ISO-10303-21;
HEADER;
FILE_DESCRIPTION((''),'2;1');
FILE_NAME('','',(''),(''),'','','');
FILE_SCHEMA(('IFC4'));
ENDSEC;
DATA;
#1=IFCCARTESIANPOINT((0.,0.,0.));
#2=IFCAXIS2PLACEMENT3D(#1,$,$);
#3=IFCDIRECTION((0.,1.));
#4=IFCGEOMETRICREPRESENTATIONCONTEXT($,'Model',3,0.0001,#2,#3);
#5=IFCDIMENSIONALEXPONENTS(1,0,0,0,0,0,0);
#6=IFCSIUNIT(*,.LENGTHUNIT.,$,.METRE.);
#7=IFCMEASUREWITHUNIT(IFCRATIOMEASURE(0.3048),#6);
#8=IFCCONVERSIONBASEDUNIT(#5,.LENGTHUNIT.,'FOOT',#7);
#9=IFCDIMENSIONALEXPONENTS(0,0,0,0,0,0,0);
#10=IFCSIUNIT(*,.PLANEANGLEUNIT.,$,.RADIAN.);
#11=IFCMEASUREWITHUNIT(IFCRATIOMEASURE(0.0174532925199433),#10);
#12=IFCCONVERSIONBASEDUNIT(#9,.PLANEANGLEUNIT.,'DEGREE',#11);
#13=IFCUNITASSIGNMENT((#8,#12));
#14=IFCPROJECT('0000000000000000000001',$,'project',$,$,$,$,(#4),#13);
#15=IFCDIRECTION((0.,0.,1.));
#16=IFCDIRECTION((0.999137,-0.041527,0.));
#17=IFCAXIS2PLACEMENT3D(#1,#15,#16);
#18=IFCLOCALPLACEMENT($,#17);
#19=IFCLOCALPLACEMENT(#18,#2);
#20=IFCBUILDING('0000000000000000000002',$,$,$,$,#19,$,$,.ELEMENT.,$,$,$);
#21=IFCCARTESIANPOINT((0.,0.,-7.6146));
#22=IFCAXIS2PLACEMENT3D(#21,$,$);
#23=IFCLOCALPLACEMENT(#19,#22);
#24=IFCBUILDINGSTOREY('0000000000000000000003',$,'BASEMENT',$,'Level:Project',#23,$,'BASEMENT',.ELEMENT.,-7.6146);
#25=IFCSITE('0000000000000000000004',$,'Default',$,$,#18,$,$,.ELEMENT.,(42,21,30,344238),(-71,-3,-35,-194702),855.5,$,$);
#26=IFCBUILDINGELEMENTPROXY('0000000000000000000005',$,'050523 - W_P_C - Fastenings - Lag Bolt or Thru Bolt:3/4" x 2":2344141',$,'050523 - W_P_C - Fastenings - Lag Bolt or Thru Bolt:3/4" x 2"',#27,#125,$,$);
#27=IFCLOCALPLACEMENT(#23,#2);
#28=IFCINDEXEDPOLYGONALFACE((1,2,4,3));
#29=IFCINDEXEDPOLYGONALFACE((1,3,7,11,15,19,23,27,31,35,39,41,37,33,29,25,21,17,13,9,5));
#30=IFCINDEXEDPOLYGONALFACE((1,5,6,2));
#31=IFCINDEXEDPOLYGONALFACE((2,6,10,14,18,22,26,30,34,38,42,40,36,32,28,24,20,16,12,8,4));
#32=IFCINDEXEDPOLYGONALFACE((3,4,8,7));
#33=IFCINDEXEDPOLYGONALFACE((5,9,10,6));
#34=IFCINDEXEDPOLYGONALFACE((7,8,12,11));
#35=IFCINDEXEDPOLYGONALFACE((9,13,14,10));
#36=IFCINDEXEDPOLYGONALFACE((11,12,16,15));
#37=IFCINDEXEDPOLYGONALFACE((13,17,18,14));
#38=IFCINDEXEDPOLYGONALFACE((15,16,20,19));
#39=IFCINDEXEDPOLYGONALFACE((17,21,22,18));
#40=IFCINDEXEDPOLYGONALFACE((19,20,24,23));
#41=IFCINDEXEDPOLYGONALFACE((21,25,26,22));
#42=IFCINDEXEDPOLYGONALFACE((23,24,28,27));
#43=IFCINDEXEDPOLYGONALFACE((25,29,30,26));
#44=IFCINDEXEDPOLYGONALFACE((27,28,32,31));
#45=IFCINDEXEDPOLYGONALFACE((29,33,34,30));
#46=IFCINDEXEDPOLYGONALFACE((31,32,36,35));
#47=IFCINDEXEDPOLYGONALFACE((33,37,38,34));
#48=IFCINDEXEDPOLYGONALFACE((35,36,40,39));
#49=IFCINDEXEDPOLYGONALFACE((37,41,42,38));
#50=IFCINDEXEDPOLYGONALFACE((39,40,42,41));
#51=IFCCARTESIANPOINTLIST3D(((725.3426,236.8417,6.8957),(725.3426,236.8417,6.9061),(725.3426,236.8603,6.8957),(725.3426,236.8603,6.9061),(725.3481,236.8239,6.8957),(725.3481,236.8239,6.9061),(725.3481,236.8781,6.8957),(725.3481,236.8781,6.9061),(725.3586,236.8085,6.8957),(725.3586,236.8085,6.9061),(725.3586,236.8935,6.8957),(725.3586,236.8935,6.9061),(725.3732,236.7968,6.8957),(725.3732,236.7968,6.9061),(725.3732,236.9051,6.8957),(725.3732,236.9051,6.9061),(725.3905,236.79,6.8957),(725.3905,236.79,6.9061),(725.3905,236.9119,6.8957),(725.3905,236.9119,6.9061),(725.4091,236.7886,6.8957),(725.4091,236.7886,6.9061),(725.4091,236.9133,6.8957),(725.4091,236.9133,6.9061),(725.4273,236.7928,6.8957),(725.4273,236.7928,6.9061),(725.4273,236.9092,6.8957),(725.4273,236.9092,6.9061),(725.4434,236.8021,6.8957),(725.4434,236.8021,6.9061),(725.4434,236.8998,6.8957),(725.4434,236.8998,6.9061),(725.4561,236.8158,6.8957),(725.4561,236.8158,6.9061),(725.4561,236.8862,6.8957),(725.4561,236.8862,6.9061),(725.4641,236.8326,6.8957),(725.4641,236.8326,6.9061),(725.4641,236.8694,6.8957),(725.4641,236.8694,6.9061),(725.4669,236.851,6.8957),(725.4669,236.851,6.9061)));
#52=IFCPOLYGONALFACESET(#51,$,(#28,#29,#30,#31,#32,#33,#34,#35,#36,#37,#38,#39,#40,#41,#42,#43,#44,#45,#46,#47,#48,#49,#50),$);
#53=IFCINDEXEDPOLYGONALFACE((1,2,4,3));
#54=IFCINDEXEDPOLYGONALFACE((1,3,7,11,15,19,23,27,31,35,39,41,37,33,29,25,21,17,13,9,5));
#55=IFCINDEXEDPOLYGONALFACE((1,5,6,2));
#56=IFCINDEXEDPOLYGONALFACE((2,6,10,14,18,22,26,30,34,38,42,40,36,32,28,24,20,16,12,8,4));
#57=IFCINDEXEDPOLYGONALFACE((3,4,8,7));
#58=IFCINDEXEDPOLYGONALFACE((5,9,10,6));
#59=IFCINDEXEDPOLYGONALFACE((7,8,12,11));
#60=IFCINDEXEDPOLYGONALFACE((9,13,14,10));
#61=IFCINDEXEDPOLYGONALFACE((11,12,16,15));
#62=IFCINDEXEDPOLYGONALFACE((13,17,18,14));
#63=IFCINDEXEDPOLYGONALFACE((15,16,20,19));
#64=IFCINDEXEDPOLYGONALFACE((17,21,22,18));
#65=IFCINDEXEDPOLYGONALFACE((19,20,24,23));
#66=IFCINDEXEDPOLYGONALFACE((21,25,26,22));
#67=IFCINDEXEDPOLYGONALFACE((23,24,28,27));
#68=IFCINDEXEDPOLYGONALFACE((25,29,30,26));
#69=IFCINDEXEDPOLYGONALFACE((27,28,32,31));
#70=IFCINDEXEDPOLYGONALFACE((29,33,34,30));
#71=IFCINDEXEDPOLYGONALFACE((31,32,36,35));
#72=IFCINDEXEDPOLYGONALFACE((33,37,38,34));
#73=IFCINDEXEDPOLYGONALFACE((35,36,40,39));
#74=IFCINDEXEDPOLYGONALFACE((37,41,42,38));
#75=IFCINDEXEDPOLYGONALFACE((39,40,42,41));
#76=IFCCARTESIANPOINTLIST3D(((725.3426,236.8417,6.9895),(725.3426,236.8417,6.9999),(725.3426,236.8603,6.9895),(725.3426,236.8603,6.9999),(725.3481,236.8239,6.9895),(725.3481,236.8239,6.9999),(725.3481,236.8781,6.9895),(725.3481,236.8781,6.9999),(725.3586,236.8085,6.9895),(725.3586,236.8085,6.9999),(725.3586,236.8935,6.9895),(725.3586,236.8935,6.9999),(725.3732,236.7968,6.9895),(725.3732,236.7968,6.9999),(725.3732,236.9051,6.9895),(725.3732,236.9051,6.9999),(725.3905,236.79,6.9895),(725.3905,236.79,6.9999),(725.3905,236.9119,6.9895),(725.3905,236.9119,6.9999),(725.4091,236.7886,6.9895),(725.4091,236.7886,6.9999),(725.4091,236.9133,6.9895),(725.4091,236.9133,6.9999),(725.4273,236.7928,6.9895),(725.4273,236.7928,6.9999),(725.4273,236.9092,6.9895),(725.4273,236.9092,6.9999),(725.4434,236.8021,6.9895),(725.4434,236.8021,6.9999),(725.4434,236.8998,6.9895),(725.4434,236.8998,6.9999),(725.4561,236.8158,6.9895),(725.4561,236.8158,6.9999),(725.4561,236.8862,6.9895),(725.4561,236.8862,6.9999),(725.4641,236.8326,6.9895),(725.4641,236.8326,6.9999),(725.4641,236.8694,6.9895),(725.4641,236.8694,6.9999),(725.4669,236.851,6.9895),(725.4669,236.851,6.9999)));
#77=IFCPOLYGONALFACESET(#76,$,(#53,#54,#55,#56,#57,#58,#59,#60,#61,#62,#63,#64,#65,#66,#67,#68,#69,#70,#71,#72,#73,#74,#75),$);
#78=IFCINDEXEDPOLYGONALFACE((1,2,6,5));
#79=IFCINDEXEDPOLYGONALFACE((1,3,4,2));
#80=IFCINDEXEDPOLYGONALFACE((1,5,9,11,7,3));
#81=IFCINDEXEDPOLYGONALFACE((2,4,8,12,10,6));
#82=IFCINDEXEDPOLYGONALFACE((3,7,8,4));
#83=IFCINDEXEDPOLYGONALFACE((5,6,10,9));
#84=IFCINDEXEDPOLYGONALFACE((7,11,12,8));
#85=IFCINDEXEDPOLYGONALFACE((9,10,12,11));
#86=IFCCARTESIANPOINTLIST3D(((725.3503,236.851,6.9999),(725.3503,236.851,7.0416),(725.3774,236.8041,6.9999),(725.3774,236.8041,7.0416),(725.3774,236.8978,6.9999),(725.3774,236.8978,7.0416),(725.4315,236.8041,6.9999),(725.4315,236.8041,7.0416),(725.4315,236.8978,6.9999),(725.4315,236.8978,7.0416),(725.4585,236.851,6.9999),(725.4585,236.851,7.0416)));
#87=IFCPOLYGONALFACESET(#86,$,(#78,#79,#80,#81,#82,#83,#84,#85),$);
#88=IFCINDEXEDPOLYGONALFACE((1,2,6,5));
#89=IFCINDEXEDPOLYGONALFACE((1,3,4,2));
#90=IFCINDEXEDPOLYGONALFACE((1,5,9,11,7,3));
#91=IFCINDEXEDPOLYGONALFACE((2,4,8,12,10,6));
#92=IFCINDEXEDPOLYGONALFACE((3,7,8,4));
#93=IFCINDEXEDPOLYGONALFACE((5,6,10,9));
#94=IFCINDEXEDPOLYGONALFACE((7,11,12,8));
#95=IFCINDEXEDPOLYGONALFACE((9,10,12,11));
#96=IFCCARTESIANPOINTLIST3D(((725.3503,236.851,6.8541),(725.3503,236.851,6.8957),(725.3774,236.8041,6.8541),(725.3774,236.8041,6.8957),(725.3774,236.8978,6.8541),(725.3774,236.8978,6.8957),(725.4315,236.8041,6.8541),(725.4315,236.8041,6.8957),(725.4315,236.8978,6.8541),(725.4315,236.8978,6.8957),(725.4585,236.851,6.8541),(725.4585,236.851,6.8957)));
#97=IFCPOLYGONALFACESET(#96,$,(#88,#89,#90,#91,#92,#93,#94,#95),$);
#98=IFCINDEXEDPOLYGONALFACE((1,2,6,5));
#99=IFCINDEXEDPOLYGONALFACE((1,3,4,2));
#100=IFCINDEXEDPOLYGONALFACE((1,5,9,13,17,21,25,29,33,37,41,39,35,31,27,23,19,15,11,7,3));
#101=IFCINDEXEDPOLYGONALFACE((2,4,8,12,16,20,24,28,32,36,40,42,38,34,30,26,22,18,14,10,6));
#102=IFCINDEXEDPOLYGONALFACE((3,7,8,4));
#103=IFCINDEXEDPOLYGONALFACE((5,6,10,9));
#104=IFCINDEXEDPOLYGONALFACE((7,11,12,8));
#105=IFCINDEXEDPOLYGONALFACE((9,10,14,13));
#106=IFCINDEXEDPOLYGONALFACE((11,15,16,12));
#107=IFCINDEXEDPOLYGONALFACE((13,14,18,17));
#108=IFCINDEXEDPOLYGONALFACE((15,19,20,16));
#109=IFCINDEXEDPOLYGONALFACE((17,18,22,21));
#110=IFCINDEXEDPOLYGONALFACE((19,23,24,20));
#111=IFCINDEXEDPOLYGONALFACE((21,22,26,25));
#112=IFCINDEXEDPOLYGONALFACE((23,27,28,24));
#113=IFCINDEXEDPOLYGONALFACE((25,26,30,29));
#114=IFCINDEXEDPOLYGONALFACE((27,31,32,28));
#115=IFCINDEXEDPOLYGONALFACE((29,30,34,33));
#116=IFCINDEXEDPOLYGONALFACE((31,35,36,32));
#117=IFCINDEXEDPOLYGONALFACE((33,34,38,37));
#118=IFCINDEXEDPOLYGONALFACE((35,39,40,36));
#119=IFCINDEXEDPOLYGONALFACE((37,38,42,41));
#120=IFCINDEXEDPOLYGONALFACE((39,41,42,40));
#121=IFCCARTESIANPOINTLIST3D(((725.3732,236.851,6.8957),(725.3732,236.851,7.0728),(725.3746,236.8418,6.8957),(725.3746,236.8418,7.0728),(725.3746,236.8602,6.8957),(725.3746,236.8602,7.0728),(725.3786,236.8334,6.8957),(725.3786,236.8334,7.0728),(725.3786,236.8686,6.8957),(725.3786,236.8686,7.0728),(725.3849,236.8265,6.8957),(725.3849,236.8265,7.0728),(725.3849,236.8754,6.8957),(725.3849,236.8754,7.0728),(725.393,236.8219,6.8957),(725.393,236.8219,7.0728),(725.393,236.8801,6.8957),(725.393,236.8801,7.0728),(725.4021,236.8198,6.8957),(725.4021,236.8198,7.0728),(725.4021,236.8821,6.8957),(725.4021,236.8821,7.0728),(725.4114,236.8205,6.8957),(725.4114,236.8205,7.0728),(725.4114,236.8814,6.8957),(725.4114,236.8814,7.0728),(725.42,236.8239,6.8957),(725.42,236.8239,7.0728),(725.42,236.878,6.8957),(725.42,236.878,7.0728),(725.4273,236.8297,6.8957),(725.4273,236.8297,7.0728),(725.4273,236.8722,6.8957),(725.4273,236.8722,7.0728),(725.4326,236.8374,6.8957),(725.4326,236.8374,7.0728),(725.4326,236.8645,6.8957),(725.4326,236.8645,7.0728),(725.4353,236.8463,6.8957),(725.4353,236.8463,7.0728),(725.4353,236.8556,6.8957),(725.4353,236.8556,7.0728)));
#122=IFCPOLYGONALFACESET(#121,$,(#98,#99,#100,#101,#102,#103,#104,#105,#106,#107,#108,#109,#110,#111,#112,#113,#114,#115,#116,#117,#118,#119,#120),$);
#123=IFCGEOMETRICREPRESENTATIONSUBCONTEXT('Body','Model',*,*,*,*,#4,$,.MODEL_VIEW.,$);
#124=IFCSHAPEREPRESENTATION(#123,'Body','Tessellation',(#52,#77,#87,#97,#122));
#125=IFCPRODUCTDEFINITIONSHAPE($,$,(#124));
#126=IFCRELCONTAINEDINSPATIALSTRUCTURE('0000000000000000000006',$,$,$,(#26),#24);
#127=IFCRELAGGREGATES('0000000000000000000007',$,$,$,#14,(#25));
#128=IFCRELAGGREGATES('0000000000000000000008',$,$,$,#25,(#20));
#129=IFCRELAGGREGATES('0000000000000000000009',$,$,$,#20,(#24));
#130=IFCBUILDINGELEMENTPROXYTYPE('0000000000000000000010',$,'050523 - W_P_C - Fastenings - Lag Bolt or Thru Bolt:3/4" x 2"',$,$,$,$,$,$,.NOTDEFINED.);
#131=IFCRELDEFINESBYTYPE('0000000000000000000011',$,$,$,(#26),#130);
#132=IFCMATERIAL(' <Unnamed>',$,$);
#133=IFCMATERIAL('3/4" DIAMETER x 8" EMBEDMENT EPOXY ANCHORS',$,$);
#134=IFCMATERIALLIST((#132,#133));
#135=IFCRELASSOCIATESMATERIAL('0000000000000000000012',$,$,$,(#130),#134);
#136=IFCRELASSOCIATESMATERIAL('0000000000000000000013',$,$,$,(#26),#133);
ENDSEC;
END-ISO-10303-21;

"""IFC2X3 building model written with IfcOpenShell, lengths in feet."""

from ifc_helpers import new_model, entity, si_unit, converted_unit, direction, frame, frame_2d, origin, place, context, subcontext, project, spatial, polyline, circle, outline, extrude, source, transform, mapped, material, material_list, type_object, type_shapes, element, save


model = new_model("IFC2X3")

# Units and contexts
model_context = context("Model", 3, precision=0.0001, world=origin(), true_north=direction((0.0, 1.0)))
body_context = subcontext(model_context, "Body", "Model", "MODEL_VIEW")
ifc_project = project(units=[converted_unit("LENGTHUNIT", "FOOT", entity("IfcRatioMeasure", 0.3048), si_unit("LENGTHUNIT", "METRE"), dimensions=[1, 0, 0, 0, 0, 0, 0]), converted_unit("PLANEANGLEUNIT", "DEGREE", entity("IfcRatioMeasure", 0.0174532925199433), si_unit("PLANEANGLEUNIT", "RADIAN"), dimensions=[0, 0, 0, 0, 0, 0, 0])], contexts=[model_context])

# Site, building, storey
site_placement = place(None, frame((0.0, 0.0, 0.0), z_axis=(0.0, 0.0, 1.0), x_axis=(0.999137, -0.041527, 0.0)))
site = spatial("IfcSite", under=ifc_project, at=site_placement, Name="Default", CompositionType="ELEMENT", RefLatitude=(42, 21, 30, 344238), RefLongitude=(-71, -3, -35, -194702), RefElevation=855.5)
building_placement = place(site_placement, origin())
building = spatial("IfcBuilding", under=site, at=building_placement, CompositionType="ELEMENT")
storey_placement = place(building_placement, frame((0.0, 0.0, -7.6146)))
storey = spatial("IfcBuildingStorey", under=building, at=storey_placement, Name="BASEMENT", ObjectType="Level:Project", LongName="BASEMENT", CompositionType="ELEMENT", Elevation=-7.6146)

# Building element proxy
ifc_material_1 = material(Name="3/4\" DIAMETER x 8\" EMBEDMENT EPOXY ANCHORS")
ifc_material_2 = material(Name=" <Unnamed>")
ifc_material_list_1 = material_list([ifc_material_2, ifc_material_1])
building_element_proxy_type_1 = type_object("IfcBuildingElementProxyType", Name="050523 - W_P_C - Fastenings - Lag Bolt or Thru Bolt:3/4\" x 2\"", PredefinedType="NOTDEFINED", material=ifc_material_list_1)
shared_shape_1 = source(origin(), body_context, "Body", "SweptSolid", [
    extrude(circle(Radius=0.0625, at=frame_2d((0.0, 0.0), x_axis=(1.0, 0.0))), frame((0.0, 0.0, 0.0), z_axis=(0.0, 0.0, 1.0), x_axis=(0.0, -1.0, 0.0)), (0.0, 0.0, 1.0), 0.0104),
    extrude(circle(Radius=0.0625, at=frame_2d((0.0, 0.0), x_axis=(1.0, 0.0))), frame((0.0, 0.0, -0.0938), z_axis=(0.0, 0.0, 1.0), x_axis=(0.0, -1.0, 0.0)), (0.0, 0.0, 1.0), 0.0104),
    extrude(outline(polyline([(-0.0271, -0.0469), (0.0271, -0.0469), (0.0541, 0.0), (0.0271, 0.0469), (-0.0271, 0.0469), (-0.0541, 0.0), (-0.0271, -0.0469)])), frame((0.0, 0.0, -0.1354), z_axis=(0.0, 0.0, 1.0), x_axis=(0.866025, -0.5, 0.0)), (0.0, 0.0, 1.0), 0.0417),
    extrude(outline(polyline([(-0.0271, -0.0469), (0.0271, -0.0469), (0.0541, 0.0), (0.0271, 0.0469), (-0.0271, 0.0469), (-0.0541, 0.0), (-0.0271, -0.0469)])), frame((0.0, 0.0, 0.0104), z_axis=(0.0, 0.0, 1.0), x_axis=(0.0, -1.0, 0.0)), (0.0, 0.0, 1.0), 0.0417),
    extrude(circle(Radius=0.0312, at=frame_2d((0.0, 0.0), x_axis=(1.0, 0.0))), frame((0.0, 0.0, -0.1667), z_axis=(0.0, 0.0, 1.0), x_axis=(0.0, 1.0, 0.0)), (0.0, 0.0, 1.0), 0.1771),
])
type_shapes(building_element_proxy_type_1, [shared_shape_1])
for number, where, z_axis, x_axis, name in (
    (1, (725.4044, 236.851, 6.9061), (0.0, 0.0, -1.0), (0.0, -1.0, 0.0), "050523 - W_P_C - Fastenings - Lag Bolt or Thru Bolt:3/4\" x 2\":2344141"),
):
    element("IfcBuildingElementProxy", number, at=place(storey_placement, frame(where, z_axis=z_axis, x_axis=x_axis)), inside=storey, type_object=building_element_proxy_type_1, material=ifc_material_1, Name=name, ObjectType="050523 - W_P_C - Fastenings - Lag Bolt or Thru Bolt:3/4\" x 2\"", context=body_context, shape_type="MappedRepresentation", body=[
        mapped(shared_shape_1, transform((0.0, 0.0, 0.0), scale=1.0)),
    ])

save(model, "model.ifc")
